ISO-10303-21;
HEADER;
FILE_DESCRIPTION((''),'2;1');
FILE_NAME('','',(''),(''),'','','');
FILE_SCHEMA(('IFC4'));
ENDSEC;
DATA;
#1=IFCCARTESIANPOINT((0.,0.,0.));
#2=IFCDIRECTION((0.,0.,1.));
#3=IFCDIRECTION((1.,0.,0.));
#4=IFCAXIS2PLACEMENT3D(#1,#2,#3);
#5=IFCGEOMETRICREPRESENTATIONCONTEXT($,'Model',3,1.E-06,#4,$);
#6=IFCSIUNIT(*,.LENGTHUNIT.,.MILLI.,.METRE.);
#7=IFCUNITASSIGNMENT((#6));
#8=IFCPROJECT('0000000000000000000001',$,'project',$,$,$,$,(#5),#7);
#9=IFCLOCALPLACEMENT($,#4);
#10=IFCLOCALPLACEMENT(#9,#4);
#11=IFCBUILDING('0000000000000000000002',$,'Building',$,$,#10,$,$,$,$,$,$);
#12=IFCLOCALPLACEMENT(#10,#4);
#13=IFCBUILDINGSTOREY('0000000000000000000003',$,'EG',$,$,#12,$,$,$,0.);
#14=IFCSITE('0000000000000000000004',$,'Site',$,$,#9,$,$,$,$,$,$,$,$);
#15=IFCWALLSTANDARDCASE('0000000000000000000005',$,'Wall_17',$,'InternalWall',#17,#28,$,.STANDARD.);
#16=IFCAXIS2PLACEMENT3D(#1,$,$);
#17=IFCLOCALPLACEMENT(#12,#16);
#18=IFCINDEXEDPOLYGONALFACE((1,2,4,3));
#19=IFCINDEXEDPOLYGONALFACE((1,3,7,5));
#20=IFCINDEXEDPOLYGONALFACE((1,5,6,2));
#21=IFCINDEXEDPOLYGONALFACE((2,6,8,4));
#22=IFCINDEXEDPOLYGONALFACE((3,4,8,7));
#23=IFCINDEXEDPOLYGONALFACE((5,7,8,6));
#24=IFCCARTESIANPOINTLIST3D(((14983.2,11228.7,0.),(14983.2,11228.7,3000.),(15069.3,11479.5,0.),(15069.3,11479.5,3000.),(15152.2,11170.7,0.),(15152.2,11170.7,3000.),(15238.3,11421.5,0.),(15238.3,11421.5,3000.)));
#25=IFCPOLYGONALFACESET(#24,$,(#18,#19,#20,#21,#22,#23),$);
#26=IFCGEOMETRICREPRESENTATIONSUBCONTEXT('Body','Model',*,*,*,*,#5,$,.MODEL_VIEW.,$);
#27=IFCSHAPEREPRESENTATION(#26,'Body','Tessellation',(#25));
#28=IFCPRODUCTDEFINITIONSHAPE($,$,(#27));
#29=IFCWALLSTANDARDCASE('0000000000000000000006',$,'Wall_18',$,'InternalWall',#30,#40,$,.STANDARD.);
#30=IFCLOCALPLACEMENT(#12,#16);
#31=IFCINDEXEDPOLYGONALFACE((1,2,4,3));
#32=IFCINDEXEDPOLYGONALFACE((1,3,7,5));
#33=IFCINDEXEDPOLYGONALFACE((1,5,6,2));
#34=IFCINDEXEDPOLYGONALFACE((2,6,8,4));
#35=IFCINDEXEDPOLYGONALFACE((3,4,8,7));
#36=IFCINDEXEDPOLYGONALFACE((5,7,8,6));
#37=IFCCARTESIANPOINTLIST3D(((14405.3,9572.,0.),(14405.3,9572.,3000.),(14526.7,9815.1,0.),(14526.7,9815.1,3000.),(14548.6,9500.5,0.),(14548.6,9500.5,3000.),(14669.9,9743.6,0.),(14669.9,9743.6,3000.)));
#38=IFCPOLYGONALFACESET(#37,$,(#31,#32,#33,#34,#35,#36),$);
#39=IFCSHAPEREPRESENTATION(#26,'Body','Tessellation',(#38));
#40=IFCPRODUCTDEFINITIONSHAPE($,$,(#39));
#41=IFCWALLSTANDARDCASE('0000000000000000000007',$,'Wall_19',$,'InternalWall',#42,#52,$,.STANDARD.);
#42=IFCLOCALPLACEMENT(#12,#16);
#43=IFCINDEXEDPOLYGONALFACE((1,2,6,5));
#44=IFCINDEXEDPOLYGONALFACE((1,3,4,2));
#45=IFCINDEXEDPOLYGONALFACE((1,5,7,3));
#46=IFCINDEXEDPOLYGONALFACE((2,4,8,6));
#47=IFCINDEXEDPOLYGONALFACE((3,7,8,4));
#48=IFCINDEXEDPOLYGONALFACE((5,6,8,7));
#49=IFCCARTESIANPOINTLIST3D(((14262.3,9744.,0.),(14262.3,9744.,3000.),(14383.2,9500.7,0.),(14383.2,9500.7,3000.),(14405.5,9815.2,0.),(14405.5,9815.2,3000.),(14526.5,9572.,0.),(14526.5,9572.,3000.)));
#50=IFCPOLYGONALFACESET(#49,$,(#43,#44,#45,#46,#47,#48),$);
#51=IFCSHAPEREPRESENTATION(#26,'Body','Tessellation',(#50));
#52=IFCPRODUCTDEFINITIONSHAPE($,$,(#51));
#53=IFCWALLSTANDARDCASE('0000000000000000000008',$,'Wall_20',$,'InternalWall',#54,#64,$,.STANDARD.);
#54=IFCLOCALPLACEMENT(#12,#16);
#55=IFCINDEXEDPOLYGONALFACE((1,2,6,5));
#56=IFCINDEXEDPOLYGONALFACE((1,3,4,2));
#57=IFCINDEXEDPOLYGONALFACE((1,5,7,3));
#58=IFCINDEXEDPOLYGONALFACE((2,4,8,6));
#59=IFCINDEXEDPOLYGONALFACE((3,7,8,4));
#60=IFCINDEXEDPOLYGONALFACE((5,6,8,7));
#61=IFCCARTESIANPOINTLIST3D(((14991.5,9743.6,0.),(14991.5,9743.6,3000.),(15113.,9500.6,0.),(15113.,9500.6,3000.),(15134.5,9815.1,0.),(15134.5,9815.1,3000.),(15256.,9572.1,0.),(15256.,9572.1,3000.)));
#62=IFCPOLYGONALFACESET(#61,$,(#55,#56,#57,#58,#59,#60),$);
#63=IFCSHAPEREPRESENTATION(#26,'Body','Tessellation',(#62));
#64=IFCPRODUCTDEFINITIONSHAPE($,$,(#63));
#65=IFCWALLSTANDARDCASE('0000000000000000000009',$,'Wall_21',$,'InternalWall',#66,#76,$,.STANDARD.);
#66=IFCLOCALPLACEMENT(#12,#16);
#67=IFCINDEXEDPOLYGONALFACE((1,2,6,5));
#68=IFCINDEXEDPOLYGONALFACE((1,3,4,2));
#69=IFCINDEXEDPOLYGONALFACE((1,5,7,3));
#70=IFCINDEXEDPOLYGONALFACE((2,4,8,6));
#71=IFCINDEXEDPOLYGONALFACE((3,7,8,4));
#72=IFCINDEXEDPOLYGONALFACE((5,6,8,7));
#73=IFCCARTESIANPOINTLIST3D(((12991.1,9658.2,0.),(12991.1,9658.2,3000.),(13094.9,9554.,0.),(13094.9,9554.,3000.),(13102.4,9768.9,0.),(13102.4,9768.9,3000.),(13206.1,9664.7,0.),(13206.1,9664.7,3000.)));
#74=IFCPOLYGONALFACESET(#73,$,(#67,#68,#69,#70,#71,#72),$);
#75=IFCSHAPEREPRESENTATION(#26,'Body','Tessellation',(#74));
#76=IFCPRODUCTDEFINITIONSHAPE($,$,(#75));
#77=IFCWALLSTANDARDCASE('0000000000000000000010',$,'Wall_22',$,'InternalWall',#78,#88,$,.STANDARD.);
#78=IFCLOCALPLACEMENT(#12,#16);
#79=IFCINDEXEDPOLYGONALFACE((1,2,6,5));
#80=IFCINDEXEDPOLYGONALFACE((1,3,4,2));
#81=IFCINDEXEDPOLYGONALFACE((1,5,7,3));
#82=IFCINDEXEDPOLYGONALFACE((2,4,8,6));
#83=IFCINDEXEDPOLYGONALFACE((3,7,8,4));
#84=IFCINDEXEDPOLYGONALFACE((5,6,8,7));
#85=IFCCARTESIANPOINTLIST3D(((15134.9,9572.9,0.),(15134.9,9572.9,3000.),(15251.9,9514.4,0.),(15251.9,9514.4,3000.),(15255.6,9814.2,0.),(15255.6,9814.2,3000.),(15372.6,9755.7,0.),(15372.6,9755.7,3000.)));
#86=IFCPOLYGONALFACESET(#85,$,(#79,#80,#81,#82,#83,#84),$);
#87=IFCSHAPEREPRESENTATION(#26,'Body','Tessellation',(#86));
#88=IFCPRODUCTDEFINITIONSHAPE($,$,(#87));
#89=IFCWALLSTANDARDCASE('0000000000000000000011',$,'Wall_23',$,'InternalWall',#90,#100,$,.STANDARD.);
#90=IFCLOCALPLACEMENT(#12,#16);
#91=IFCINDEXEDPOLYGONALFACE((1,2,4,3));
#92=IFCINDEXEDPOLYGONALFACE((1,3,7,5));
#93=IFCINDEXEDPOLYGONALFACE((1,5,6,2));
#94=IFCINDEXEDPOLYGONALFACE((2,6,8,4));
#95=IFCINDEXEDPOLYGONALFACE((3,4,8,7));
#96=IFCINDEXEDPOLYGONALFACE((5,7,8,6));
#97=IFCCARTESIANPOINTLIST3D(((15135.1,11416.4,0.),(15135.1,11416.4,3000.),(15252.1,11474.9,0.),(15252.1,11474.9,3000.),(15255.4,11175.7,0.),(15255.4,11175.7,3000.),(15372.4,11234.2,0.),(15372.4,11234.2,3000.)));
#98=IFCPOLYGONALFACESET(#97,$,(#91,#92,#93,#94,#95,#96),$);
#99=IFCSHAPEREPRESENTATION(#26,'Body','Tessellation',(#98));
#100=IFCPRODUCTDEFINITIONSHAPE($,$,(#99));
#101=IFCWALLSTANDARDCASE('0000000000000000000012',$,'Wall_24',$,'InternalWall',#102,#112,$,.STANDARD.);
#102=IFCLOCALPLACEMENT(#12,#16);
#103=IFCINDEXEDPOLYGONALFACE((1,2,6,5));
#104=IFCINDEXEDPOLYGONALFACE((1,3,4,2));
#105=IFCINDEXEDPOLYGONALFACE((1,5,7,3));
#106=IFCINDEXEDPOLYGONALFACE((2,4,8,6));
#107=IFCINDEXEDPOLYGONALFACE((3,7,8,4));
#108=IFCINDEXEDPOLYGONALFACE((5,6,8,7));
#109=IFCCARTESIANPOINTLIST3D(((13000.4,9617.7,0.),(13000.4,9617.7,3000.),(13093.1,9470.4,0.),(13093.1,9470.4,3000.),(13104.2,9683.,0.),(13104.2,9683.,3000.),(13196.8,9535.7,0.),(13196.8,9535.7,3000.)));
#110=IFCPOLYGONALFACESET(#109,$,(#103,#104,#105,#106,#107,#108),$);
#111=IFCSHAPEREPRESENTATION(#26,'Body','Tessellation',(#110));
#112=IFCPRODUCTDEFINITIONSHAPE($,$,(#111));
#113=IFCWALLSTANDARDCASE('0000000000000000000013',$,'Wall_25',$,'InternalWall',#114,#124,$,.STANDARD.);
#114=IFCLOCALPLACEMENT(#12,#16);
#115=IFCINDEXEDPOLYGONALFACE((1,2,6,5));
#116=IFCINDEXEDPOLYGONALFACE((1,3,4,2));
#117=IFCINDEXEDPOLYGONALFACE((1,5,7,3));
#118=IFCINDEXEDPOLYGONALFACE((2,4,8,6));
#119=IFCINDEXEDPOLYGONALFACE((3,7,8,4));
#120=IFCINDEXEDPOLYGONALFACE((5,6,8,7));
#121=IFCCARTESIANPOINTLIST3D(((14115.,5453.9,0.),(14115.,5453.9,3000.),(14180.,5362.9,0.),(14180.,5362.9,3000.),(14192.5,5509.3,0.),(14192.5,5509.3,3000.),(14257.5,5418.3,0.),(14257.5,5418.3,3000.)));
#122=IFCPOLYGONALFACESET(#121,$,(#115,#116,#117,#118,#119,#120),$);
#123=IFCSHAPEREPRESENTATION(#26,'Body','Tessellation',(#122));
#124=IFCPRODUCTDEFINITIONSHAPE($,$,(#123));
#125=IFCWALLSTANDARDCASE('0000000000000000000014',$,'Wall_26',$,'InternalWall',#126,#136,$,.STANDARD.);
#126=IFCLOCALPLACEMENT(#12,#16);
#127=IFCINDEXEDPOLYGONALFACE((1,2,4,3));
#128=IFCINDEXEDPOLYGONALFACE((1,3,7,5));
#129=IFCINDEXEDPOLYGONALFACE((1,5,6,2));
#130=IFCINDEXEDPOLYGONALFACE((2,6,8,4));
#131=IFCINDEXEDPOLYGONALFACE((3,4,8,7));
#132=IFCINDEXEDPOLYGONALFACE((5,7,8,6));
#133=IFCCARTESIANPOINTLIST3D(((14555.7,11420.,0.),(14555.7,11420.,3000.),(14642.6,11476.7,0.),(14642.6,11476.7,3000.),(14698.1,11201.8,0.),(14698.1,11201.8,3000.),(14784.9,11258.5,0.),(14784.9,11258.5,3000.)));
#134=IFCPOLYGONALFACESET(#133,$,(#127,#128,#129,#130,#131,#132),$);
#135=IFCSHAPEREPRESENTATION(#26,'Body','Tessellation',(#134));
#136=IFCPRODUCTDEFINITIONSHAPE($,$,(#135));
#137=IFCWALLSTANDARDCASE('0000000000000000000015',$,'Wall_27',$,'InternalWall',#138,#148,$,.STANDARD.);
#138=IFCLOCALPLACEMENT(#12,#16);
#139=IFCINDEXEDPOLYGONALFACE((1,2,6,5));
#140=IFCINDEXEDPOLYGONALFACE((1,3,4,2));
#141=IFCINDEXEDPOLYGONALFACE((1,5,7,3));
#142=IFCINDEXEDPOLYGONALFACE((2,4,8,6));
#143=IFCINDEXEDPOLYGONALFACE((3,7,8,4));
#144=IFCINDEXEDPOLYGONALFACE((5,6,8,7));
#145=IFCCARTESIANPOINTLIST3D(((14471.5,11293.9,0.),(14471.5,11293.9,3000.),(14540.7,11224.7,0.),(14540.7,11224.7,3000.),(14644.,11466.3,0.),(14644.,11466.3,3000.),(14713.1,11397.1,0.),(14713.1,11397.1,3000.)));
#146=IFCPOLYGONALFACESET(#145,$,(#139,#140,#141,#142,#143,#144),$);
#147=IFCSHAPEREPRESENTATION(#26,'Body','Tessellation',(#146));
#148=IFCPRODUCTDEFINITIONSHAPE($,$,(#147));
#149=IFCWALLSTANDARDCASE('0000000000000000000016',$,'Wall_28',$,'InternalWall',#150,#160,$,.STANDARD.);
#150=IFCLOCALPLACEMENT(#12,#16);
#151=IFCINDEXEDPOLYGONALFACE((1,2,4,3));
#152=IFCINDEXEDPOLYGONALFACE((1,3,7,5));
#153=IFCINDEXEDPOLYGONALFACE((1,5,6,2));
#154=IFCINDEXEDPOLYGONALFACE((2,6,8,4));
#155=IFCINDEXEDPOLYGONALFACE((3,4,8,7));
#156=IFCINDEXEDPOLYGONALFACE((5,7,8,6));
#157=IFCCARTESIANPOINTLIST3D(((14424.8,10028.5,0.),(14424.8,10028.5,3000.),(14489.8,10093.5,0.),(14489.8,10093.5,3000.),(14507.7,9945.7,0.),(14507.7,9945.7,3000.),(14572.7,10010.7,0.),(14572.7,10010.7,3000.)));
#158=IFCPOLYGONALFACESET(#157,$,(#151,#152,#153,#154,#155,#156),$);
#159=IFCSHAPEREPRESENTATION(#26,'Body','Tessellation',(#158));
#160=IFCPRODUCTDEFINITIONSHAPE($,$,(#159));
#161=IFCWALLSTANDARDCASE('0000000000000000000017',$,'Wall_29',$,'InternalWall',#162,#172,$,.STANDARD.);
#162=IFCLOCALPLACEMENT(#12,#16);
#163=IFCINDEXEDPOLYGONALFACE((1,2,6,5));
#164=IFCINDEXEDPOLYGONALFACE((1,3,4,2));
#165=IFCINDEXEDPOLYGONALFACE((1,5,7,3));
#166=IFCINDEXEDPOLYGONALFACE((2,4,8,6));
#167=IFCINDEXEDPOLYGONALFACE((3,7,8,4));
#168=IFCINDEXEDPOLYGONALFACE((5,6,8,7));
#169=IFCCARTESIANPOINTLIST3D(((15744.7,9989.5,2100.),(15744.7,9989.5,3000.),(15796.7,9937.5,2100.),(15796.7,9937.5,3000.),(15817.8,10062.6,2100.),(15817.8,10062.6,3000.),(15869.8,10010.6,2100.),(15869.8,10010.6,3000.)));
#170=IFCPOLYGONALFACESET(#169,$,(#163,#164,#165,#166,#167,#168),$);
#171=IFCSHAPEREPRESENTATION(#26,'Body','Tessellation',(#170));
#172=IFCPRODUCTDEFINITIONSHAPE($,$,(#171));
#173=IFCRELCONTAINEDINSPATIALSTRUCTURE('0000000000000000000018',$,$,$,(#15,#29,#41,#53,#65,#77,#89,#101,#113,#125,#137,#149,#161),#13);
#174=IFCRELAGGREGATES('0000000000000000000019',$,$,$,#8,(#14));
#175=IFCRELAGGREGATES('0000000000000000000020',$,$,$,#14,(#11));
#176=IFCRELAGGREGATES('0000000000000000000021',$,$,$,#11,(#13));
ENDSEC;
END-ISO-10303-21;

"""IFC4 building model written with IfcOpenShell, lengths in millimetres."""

from ifc_helpers import new_model, si_unit, frame, origin_with_axes, place, context, subcontext, project, spatial, rectangle, extrude, element, save


model = new_model("IFC4")

# Units and contexts
model_context = context("Model", 3, precision=1e-06, world=origin_with_axes())
body_context = subcontext(model_context, "Body", "Model", "MODEL_VIEW")
ifc_project = project(units=[si_unit("LENGTHUNIT", "METRE", prefix="MILLI")], contexts=[model_context])

# Site, building, storey
site_placement = place(None, origin_with_axes())
site = spatial("IfcSite", under=ifc_project, at=site_placement, Name="Site")
building_placement = place(site_placement, origin_with_axes())
building = spatial("IfcBuilding", under=site, at=building_placement, Name="Building")
storey_placement = place(building_placement, origin_with_axes())
storey = spatial("IfcBuildingStorey", under=building, at=storey_placement, Name="EG", Elevation=0.0)

# Walls
wall_1_placement = place(storey_placement, origin_with_axes())
element("IfcWallStandardCase", 1, at=wall_1_placement, inside=storey, Name="Wall_17", ObjectType="InternalWall", PredefinedType="STANDARD", context=body_context, shape_type="SweptSolid", body=[
    extrude(rectangle(XDim=178.7, YDim=265.1), frame((15110.8, 11325.1, 0.0), z_axis=(0.0, 0.0, 1.0), x_axis=(-0.945848, 0.32461, 0.0)), (0.0, 0.0, 1.0), 3000.0),
])
wall_2_placement = place(storey_placement, origin_with_axes())
element("IfcWallStandardCase", 2, at=wall_2_placement, inside=storey, Name="Wall_18", ObjectType="InternalWall", PredefinedType="STANDARD", context=body_context, shape_type="SweptSolid", body=[
    extrude(rectangle(XDim=160.1, YDim=271.7), frame((14537.6, 9657.8, 0.0), z_axis=(0.0, 0.0, 1.0), x_axis=(-0.894739, 0.446589, 0.0)), (0.0, 0.0, 1.0), 3000.0),
])
wall_3_placement = place(storey_placement, origin_with_axes())
element("IfcWallStandardCase", 3, at=wall_3_placement, inside=storey, Name="Wall_19", ObjectType="InternalWall", PredefinedType="STANDARD", context=body_context, shape_type="SweptSolid", body=[
    extrude(rectangle(XDim=160.0, YDim=271.7), frame((14394.4, 9658.0, 0.0), z_axis=(0.0, 0.0, 1.0), x_axis=(-0.895363, -0.445338, 0.0)), (0.0, 0.0, 1.0), 3000.0),
])
wall_4_placement = place(storey_placement, origin_with_axes())
element("IfcWallStandardCase", 4, at=wall_4_placement, inside=storey, Name="Wall_20", ObjectType="InternalWall", PredefinedType="STANDARD", context=body_context, shape_type="SweptSolid", body=[
    extrude(rectangle(XDim=159.9, YDim=271.7), frame((15123.8, 9657.8, 0.0), z_axis=(0.0, 0.0, 1.0), x_axis=(0.894427, 0.447214, 0.0)), (0.0, 0.0, 1.0), 3000.0),
])
wall_5_placement = place(storey_placement, origin_with_axes())
element("IfcWallStandardCase", 5, at=wall_5_placement, inside=storey, Name="Wall_21", ObjectType="InternalWall", PredefinedType="STANDARD", context=body_context, shape_type="SweptSolid", body=[
    extrude(rectangle(XDim=147.1, YDim=156.9), frame((13098.6, 9661.5, 0.0), z_axis=(0.0, 0.0, 1.0), x_axis=(-0.705405, 0.708805, 0.0)), (0.0, 0.0, 1.0), 3000.0),
])
wall_6_placement = place(storey_placement, origin_with_axes())
element("IfcWallStandardCase", 6, at=wall_6_placement, inside=storey, Name="Wall_22", ObjectType="InternalWall", PredefinedType="STANDARD", context=body_context, shape_type="SweptSolid", body=[
    extrude(rectangle(XDim=130.8, YDim=269.8), frame((15253.8, 9664.3, 0.0), z_axis=(0.0, 0.0, 1.0), x_axis=(0.894427, -0.447214, 0.0)), (0.0, 0.0, 1.0), 3000.0),
])
wall_7_placement = place(storey_placement, origin_with_axes())
element("IfcWallStandardCase", 7, at=wall_7_placement, inside=storey, Name="Wall_23", ObjectType="InternalWall", PredefinedType="STANDARD", context=body_context, shape_type="SweptSolid", body=[
    extrude(rectangle(XDim=130.8, YDim=269.1), frame((15253.8, 11325.3, 0.0), z_axis=(0.0, 0.0, 1.0), x_axis=(-0.894427, -0.447214, 0.0)), (0.0, 0.0, 1.0), 3000.0),
])
wall_8_placement = place(storey_placement, origin_with_axes())
element("IfcWallStandardCase", 8, at=wall_8_placement, inside=storey, Name="Wall_24", ObjectType="InternalWall", PredefinedType="STANDARD", context=body_context, shape_type="SweptSolid", body=[
    extrude(rectangle(XDim=122.6, YDim=174.0), frame((13098.6, 9576.7, 0.0), z_axis=(0.0, 0.0, 1.0), x_axis=(-0.846505, -0.53238, 0.0)), (0.0, 0.0, 1.0), 3000.0),
])
wall_9_placement = place(storey_placement, origin_with_axes())
element("IfcWallStandardCase", 9, at=wall_9_placement, inside=storey, Name="Wall_25", ObjectType="InternalWall", PredefinedType="STANDARD", context=body_context, shape_type="SweptSolid", body=[
    extrude(rectangle(XDim=111.8, YDim=95.4), frame((14186.3, 5436.1, 0.0), z_axis=(0.0, 0.0, 1.0), x_axis=(0.581238, -0.813733, 0.0)), (0.0, 0.0, 1.0), 3000.0),
])
wall_10_placement = place(storey_placement, origin_with_axes())
element("IfcWallStandardCase", 10, at=wall_10_placement, inside=storey, Name="Wall_26", ObjectType="InternalWall", PredefinedType="STANDARD", context=body_context, shape_type="SweptSolid", body=[
    extrude(rectangle(XDim=103.7, YDim=260.5), frame((14670.3, 11339.3, 0.0), z_axis=(0.0, 0.0, 1.0), x_axis=(-0.837451, -0.546513, 0.0)), (0.0, 0.0, 1.0), 3000.0),
])
wall_11_placement = place(storey_placement, origin_with_axes())
element("IfcWallStandardCase", 11, at=wall_11_placement, inside=storey, Name="Wall_27", ObjectType="InternalWall", PredefinedType="STANDARD", context=body_context, shape_type="SweptSolid", body=[
    extrude(rectangle(XDim=97.8, YDim=243.8), frame((14592.3, 11345.5, 0.0), z_axis=(0.0, 0.0, 1.0), x_axis=(-0.707107, 0.707107, 0.0)), (0.0, 0.0, 1.0), 3000.0),
])
wall_12_placement = place(storey_placement, origin_with_axes())
element("IfcWallStandardCase", 12, at=wall_12_placement, inside=storey, Name="Wall_28", ObjectType="InternalWall", PredefinedType="STANDARD", context=body_context, shape_type="SweptSolid", body=[
    extrude(rectangle(XDim=91.9, YDim=117.1), frame((14498.8, 10019.6, 0.0), z_axis=(0.0, 0.0, 1.0), x_axis=(-0.707107, -0.707107, 0.0)), (0.0, 0.0, 1.0), 3000.0),
])

# Wall, opening
wall_13_placement = place(storey_placement, origin_with_axes())
wall_13 = element("IfcWallStandardCase", 13, at=wall_13_placement, inside=storey, Name="Wall_29", ObjectType="InternalWall", PredefinedType="STANDARD", context=body_context, shape_type="SweptSolid", body=[
    extrude(rectangle(XDim=73.5, YDim=103.4), frame((15807.3, 10000.1, 0.0), z_axis=(0.0, 0.0, 1.0), x_axis=(-0.707107, 0.707107, 0.0)), (0.0, 0.0, 1.0), 3000.0),
])
opening_1_placement = place(wall_13_placement, origin_with_axes())
element("IfcOpeningElement", 14, at=opening_1_placement, inside=storey, cuts=wall_13, context=body_context, shape_type="SweptSolid", body=[
    extrude(rectangle(XDim=450.0, YDim=103.4), frame((15807.3, 10000.1, 0.0), z_axis=(0.0, 0.0, 1.0), x_axis=(-0.707107, 0.707107, 0.0)), (0.0, 0.0, 1.0), 2100.0),
])

save(model, "model.ifc")
